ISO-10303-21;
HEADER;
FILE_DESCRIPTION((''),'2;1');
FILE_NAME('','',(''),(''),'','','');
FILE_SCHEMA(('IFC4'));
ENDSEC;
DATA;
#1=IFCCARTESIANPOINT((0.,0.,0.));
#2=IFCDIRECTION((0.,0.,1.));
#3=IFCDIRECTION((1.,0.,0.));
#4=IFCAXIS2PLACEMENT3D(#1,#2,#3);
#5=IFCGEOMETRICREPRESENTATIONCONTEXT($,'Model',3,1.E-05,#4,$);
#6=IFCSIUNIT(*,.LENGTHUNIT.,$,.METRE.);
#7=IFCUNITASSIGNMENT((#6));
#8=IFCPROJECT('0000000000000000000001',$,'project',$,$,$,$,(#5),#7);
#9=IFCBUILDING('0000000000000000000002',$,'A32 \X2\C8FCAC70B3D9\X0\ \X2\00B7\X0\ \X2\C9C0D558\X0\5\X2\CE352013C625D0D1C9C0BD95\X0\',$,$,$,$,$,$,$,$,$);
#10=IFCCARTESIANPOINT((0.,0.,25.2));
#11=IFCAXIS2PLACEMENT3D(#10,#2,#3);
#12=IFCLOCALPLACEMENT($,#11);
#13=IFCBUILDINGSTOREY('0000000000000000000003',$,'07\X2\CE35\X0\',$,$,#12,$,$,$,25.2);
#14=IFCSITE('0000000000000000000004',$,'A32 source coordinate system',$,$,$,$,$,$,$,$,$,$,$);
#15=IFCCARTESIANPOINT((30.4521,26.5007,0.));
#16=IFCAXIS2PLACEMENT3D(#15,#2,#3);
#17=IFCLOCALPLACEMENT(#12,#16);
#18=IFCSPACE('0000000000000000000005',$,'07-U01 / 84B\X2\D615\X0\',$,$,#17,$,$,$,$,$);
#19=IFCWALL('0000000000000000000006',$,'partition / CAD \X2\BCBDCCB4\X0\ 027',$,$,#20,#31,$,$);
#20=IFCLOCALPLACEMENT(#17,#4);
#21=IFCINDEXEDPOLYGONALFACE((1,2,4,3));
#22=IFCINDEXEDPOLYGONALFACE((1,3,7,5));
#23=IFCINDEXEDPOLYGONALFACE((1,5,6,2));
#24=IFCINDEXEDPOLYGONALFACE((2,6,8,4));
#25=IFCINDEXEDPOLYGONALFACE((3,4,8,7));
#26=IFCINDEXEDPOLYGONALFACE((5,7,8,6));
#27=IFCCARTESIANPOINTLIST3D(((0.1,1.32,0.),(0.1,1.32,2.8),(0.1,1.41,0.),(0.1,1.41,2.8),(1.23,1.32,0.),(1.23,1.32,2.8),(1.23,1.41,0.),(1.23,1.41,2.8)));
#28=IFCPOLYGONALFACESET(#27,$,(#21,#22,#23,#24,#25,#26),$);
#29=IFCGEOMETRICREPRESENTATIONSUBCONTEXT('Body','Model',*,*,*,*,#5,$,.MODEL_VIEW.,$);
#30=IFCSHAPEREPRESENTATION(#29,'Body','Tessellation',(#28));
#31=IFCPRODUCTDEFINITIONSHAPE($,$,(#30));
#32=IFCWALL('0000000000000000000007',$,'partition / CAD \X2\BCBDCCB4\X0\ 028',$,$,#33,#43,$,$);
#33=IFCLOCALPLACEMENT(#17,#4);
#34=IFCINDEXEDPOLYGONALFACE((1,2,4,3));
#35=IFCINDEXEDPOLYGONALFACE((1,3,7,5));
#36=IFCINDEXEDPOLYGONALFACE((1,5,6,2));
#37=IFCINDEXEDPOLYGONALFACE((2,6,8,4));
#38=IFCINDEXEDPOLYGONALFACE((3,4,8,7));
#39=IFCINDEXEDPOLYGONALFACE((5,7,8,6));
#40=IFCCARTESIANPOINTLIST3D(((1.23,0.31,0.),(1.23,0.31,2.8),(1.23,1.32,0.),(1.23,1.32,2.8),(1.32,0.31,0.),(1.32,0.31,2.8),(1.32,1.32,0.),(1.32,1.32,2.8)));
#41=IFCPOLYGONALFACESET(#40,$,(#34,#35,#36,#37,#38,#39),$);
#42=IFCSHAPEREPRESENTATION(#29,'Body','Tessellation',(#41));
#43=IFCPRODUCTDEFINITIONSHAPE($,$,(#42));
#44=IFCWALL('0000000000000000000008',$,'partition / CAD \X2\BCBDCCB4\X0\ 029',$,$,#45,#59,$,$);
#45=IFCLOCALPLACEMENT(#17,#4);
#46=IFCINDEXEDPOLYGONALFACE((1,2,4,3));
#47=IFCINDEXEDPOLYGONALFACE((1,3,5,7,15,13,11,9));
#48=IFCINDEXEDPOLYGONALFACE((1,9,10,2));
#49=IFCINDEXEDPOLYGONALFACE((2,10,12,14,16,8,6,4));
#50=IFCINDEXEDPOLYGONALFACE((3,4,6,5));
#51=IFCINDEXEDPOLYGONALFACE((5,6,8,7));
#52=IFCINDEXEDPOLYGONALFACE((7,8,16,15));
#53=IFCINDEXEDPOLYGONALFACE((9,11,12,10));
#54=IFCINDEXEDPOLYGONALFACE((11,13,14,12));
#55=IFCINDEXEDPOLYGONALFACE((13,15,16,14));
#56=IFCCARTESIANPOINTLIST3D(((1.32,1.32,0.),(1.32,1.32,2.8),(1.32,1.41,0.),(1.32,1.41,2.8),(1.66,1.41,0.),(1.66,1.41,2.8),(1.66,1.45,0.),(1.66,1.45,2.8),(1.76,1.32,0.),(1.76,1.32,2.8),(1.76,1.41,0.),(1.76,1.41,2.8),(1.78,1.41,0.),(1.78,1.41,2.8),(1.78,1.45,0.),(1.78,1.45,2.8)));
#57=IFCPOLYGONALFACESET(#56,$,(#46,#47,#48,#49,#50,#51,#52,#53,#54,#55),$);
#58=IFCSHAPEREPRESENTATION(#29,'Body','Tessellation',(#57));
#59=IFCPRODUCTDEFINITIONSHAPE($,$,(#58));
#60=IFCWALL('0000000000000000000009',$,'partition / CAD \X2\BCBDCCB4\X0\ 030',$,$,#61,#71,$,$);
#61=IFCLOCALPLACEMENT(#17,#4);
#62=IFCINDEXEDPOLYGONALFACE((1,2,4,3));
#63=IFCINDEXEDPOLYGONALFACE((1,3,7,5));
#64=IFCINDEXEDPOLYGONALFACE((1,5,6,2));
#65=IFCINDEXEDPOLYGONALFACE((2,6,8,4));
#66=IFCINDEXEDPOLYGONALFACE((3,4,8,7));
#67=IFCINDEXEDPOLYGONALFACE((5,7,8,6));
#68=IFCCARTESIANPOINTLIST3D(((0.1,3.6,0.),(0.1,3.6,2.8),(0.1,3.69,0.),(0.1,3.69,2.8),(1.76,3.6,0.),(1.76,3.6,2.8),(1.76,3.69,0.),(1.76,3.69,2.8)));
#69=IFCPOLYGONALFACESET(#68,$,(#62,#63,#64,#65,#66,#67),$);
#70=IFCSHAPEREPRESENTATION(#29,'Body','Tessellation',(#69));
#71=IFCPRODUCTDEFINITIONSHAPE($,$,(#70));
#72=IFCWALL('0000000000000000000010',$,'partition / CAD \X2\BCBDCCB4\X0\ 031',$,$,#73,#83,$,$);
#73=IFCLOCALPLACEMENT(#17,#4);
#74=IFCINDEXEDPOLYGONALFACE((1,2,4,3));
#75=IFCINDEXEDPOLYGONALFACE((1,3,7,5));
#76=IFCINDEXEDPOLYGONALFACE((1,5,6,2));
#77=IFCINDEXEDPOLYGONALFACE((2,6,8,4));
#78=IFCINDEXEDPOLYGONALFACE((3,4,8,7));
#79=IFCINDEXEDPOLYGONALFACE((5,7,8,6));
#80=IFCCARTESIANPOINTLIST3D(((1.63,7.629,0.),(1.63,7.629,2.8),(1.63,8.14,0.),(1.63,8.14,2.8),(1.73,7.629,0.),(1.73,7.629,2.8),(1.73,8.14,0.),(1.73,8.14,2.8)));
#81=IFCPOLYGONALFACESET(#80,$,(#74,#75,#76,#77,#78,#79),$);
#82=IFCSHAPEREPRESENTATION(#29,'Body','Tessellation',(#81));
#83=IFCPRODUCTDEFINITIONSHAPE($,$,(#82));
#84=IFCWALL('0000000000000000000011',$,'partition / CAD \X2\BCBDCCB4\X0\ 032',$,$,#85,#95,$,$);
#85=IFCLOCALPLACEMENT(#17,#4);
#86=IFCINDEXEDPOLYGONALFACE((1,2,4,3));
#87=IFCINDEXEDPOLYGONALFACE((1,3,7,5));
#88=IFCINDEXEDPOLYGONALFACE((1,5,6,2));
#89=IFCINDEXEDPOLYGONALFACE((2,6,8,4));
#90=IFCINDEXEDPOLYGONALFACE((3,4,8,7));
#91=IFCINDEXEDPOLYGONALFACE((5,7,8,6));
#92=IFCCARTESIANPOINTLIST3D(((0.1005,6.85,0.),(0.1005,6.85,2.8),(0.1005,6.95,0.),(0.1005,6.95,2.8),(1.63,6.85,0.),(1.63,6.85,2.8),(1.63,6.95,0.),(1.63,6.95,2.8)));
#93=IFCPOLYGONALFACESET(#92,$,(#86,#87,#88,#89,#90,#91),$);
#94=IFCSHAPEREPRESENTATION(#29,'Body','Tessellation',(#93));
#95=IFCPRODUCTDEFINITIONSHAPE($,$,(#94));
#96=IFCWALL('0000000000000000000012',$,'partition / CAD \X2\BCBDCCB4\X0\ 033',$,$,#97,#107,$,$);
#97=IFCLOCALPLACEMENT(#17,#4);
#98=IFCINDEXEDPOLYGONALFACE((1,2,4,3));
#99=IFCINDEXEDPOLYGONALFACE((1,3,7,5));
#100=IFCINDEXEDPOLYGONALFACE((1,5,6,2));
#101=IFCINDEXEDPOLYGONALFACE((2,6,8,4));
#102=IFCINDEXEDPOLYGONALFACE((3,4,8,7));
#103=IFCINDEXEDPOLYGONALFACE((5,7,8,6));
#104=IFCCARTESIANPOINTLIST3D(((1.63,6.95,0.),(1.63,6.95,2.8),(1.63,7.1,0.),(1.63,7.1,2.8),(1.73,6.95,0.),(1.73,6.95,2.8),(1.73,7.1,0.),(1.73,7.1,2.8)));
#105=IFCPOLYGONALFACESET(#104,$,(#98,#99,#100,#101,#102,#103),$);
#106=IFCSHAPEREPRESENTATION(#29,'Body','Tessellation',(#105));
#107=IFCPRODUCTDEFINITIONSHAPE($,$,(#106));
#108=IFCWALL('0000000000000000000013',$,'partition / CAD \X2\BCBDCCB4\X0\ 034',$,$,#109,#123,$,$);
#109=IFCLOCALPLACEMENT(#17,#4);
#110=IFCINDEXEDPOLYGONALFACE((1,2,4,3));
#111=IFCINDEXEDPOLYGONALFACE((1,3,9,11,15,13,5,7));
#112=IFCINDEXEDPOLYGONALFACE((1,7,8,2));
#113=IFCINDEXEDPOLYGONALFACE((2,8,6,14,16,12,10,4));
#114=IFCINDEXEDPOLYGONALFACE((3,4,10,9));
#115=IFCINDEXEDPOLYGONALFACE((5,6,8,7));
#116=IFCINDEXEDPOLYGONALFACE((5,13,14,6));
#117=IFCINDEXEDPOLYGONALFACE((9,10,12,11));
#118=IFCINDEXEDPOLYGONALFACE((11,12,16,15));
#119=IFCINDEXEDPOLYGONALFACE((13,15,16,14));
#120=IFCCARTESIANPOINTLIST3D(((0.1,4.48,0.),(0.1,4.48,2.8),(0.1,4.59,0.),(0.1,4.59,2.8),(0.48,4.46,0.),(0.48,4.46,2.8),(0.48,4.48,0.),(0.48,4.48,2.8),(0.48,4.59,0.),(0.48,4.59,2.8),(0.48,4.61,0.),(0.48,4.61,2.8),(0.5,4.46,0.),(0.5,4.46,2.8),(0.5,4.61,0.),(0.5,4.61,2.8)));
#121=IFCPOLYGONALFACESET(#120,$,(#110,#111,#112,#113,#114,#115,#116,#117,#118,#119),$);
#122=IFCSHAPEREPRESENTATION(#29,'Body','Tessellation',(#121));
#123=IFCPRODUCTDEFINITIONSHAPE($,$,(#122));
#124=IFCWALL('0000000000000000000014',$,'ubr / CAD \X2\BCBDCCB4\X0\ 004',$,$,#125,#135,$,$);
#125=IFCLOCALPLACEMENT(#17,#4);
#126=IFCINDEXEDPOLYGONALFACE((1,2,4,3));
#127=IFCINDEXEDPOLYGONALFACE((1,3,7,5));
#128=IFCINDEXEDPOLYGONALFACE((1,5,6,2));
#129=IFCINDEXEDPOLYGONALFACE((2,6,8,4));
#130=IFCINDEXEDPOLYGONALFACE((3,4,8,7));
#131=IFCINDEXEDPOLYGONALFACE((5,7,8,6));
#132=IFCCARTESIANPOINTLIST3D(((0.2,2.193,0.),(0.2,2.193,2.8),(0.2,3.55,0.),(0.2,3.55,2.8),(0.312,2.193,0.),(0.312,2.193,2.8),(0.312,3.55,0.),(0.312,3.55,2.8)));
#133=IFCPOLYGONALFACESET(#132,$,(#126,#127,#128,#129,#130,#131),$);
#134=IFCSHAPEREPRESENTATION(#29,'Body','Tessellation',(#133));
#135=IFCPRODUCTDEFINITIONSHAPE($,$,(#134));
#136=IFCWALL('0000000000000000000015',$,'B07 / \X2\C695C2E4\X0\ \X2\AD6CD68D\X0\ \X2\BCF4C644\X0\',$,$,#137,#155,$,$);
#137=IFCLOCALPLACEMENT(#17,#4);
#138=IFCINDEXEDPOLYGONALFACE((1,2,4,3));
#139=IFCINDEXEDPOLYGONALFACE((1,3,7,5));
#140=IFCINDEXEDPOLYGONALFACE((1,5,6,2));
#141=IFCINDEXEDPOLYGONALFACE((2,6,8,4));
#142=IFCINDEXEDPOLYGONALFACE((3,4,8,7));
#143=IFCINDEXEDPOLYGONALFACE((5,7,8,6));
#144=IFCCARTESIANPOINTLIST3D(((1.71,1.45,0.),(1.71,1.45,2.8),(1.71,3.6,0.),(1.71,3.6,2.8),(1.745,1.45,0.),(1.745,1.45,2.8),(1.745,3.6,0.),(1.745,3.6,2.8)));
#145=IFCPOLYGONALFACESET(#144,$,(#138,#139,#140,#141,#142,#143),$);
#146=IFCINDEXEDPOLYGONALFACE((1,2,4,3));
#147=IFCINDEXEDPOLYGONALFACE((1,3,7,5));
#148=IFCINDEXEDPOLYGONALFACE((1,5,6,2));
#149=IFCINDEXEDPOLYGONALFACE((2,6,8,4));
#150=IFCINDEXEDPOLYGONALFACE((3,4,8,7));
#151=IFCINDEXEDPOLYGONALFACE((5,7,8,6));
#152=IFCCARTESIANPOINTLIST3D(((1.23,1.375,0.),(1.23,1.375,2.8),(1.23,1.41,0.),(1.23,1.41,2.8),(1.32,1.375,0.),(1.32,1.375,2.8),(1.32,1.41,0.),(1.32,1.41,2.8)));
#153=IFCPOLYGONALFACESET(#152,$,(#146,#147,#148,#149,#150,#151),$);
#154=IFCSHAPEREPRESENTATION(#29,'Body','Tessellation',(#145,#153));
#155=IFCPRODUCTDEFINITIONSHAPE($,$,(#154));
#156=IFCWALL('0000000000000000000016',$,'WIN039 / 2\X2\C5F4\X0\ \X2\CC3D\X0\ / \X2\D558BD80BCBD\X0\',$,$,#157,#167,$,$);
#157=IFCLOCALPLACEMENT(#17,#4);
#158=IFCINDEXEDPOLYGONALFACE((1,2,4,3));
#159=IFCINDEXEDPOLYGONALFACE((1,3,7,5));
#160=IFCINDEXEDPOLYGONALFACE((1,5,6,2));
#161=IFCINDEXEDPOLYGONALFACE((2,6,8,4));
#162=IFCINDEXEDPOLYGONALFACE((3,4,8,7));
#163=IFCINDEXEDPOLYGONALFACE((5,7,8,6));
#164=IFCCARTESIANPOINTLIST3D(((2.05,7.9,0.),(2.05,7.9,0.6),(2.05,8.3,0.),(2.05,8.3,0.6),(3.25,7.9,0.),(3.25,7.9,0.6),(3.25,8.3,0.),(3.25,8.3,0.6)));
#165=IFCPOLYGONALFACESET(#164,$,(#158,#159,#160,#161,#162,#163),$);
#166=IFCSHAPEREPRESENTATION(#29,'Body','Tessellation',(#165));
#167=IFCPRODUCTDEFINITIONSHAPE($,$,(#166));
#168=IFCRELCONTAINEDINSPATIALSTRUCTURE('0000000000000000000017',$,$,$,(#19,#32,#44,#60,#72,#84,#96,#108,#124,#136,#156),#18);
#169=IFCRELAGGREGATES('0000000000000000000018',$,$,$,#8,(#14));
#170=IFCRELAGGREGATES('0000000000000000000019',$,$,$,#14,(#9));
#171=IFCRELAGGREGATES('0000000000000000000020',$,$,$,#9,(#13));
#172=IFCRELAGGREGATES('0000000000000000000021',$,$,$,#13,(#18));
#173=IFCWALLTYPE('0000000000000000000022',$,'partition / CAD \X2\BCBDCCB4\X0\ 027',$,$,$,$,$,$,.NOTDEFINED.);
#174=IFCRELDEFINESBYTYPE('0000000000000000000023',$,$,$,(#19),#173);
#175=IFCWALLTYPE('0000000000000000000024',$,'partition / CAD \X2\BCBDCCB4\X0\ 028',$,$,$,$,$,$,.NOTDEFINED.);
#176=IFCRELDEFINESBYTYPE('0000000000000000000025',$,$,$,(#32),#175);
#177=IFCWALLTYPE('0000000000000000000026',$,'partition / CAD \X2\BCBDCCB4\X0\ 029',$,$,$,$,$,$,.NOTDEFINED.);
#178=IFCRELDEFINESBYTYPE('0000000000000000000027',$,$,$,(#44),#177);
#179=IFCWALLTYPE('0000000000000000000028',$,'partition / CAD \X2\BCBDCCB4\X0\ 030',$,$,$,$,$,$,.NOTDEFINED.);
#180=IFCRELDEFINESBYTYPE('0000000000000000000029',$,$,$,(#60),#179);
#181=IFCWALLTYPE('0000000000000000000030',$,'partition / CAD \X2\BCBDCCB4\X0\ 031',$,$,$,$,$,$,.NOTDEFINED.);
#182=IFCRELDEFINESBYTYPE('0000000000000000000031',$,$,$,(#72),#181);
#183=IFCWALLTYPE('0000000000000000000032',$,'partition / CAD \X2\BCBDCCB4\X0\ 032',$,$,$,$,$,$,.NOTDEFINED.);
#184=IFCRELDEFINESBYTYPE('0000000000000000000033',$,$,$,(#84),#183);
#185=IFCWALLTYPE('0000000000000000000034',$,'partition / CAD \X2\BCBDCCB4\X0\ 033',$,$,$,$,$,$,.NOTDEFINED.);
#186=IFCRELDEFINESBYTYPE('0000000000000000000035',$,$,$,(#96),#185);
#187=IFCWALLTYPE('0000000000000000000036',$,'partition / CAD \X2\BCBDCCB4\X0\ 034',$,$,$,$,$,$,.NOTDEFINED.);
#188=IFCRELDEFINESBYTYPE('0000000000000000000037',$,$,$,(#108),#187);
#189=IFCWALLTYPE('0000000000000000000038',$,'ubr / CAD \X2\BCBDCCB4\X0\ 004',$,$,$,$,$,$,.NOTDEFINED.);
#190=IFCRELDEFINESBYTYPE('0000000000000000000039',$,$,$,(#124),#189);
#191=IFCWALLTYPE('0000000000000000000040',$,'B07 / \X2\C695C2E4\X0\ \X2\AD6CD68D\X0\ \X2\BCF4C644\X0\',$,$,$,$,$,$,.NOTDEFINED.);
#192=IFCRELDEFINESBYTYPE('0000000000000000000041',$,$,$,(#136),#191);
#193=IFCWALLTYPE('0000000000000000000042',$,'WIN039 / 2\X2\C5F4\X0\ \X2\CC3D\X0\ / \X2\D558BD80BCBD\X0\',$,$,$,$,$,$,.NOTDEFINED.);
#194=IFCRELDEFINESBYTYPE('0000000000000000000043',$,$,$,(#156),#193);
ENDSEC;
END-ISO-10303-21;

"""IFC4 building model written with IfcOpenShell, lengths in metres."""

from ifc_helpers import new_model, si_unit, frame, origin, origin_with_axes, place, context, subcontext, project, spatial, polyline, outline, extrude, source, transform, mapped, type_object, type_shapes, element, save


model = new_model("IFC4")

# Units and contexts
model_context = context("Model", 3, precision=1e-05, world=origin_with_axes())
body_context = subcontext(model_context, "Body", "Model", "MODEL_VIEW")
ifc_project = project(units=[si_unit("LENGTHUNIT", "METRE")], contexts=[model_context])

# Site, building, storey, space
site = spatial("IfcSite", under=ifc_project, Name="A32 source coordinate system")
building = spatial("IfcBuilding", under=site, Name="A32 주거동 · 지하5층–옥탑지붕")
storey_placement = place(None, frame((0.0, 0.0, 25.2), z_axis=(0.0, 0.0, 1.0), x_axis=(1.0, 0.0, 0.0)))
storey = spatial("IfcBuildingStorey", under=building, at=storey_placement, Name="07층", Elevation=25.2)
space_placement = place(storey_placement, frame((30.4521, 26.5007, 0.0), z_axis=(0.0, 0.0, 1.0), x_axis=(1.0, 0.0, 0.0)))
space = spatial("IfcSpace", under=storey, at=space_placement, Name="07-U01 / 84B형")

# Walls
wall_type_1 = type_object("IfcWallType", Name="partition / CAD 벽체 027", PredefinedType="NOTDEFINED")
shared_shape_1 = source(origin(), body_context, "Body", "SweptSolid", [
    extrude(outline(polyline([(0.1, 1.32), (0.1, 1.41), (1.23, 1.41), (1.23, 1.32), (0.1, 1.32)])), origin(), (0.0, 0.0, 1.0), 2.8),
])
type_shapes(wall_type_1, [shared_shape_1])
wall_1_placement = place(space_placement, origin_with_axes())
element("IfcWall", 1, at=wall_1_placement, inside=space, type_object=wall_type_1, Name="partition / CAD 벽체 027", context=body_context, shape_type="MappedRepresentation", body=[
    mapped(shared_shape_1, transform((0.0, 0.0, 0.0), scale=1.0)),
])
wall_type_2 = type_object("IfcWallType", Name="partition / CAD 벽체 028", PredefinedType="NOTDEFINED")
shared_shape_2 = source(origin(), body_context, "Body", "SweptSolid", [
    extrude(outline(polyline([(1.32, 0.31), (1.23, 0.31), (1.23, 1.32), (1.32, 1.32), (1.32, 0.31)])), origin(), (0.0, 0.0, 1.0), 2.8),
])
type_shapes(wall_type_2, [shared_shape_2])
wall_2_placement = place(space_placement, origin_with_axes())
element("IfcWall", 2, at=wall_2_placement, inside=space, type_object=wall_type_2, Name="partition / CAD 벽체 028", context=body_context, shape_type="MappedRepresentation", body=[
    mapped(shared_shape_2, transform((0.0, 0.0, 0.0), scale=1.0)),
])
wall_type_3 = type_object("IfcWallType", Name="partition / CAD 벽체 029", PredefinedType="NOTDEFINED")
shared_shape_3 = source(origin(), body_context, "Body", "SweptSolid", [
    extrude(outline(polyline([(1.66, 1.41), (1.66, 1.45), (1.78, 1.45), (1.78, 1.41), (1.76, 1.41), (1.76, 1.32), (1.32, 1.32), (1.32, 1.41), (1.66, 1.41)])), origin(), (0.0, 0.0, 1.0), 2.8),
])
type_shapes(wall_type_3, [shared_shape_3])
wall_3_placement = place(space_placement, origin_with_axes())
element("IfcWall", 3, at=wall_3_placement, inside=space, type_object=wall_type_3, Name="partition / CAD 벽체 029", context=body_context, shape_type="MappedRepresentation", body=[
    mapped(shared_shape_3, transform((0.0, 0.0, 0.0), scale=1.0)),
])
wall_type_4 = type_object("IfcWallType", Name="partition / CAD 벽체 030", PredefinedType="NOTDEFINED")
shared_shape_4 = source(origin(), body_context, "Body", "SweptSolid", [
    extrude(outline(polyline([(1.76, 3.69), (1.76, 3.6), (0.1, 3.6), (0.1, 3.69), (1.76, 3.69)])), origin(), (0.0, 0.0, 1.0), 2.8),
])
type_shapes(wall_type_4, [shared_shape_4])
wall_4_placement = place(space_placement, origin_with_axes())
element("IfcWall", 4, at=wall_4_placement, inside=space, type_object=wall_type_4, Name="partition / CAD 벽체 030", context=body_context, shape_type="MappedRepresentation", body=[
    mapped(shared_shape_4, transform((0.0, 0.0, 0.0), scale=1.0)),
])
wall_type_5 = type_object("IfcWallType", Name="partition / CAD 벽체 031", PredefinedType="NOTDEFINED")
shared_shape_5 = source(origin(), body_context, "Body", "SweptSolid", [
    extrude(outline(polyline([(1.63, 8.14), (1.73, 8.14), (1.73, 7.629), (1.63, 7.629), (1.63, 8.14)])), origin(), (0.0, 0.0, 1.0), 2.8),
])
type_shapes(wall_type_5, [shared_shape_5])
wall_5_placement = place(space_placement, origin_with_axes())
element("IfcWall", 5, at=wall_5_placement, inside=space, type_object=wall_type_5, Name="partition / CAD 벽체 031", context=body_context, shape_type="MappedRepresentation", body=[
    mapped(shared_shape_5, transform((0.0, 0.0, 0.0), scale=1.0)),
])
wall_type_6 = type_object("IfcWallType", Name="partition / CAD 벽체 032", PredefinedType="NOTDEFINED")
shared_shape_6 = source(origin(), body_context, "Body", "SweptSolid", [
    extrude(outline(polyline([(0.1005, 6.95), (1.63, 6.95), (1.63, 6.85), (0.1005, 6.85), (0.1005, 6.95)])), origin(), (0.0, 0.0, 1.0), 2.8),
])
type_shapes(wall_type_6, [shared_shape_6])
wall_6_placement = place(space_placement, origin_with_axes())
element("IfcWall", 6, at=wall_6_placement, inside=space, type_object=wall_type_6, Name="partition / CAD 벽체 032", context=body_context, shape_type="MappedRepresentation", body=[
    mapped(shared_shape_6, transform((0.0, 0.0, 0.0), scale=1.0)),
])
wall_type_7 = type_object("IfcWallType", Name="partition / CAD 벽체 033", PredefinedType="NOTDEFINED")
shared_shape_7 = source(origin(), body_context, "Body", "SweptSolid", [
    extrude(outline(polyline([(1.63, 7.1), (1.73, 7.1), (1.73, 6.95), (1.63, 6.95), (1.63, 7.1)])), origin(), (0.0, 0.0, 1.0), 2.8),
])
type_shapes(wall_type_7, [shared_shape_7])
wall_7_placement = place(space_placement, origin_with_axes())
element("IfcWall", 7, at=wall_7_placement, inside=space, type_object=wall_type_7, Name="partition / CAD 벽체 033", context=body_context, shape_type="MappedRepresentation", body=[
    mapped(shared_shape_7, transform((0.0, 0.0, 0.0), scale=1.0)),
])
wall_type_8 = type_object("IfcWallType", Name="partition / CAD 벽체 034", PredefinedType="NOTDEFINED")
shared_shape_8 = source(origin(), body_context, "Body", "SweptSolid", [
    extrude(outline(polyline([(0.48, 4.61), (0.5, 4.61), (0.5, 4.46), (0.48, 4.46), (0.48, 4.48), (0.1, 4.48), (0.1, 4.59), (0.48, 4.59), (0.48, 4.61)])), origin(), (0.0, 0.0, 1.0), 2.8),
])
type_shapes(wall_type_8, [shared_shape_8])
wall_8_placement = place(space_placement, origin_with_axes())
element("IfcWall", 8, at=wall_8_placement, inside=space, type_object=wall_type_8, Name="partition / CAD 벽체 034", context=body_context, shape_type="MappedRepresentation", body=[
    mapped(shared_shape_8, transform((0.0, 0.0, 0.0), scale=1.0)),
])
wall_type_9 = type_object("IfcWallType", Name="ubr / CAD 벽체 004", PredefinedType="NOTDEFINED")
shared_shape_9 = source(origin(), body_context, "Body", "SweptSolid", [
    extrude(outline(polyline([(0.312, 2.193), (0.2, 2.193), (0.2, 3.55), (0.312, 3.55), (0.312, 2.193)])), origin(), (0.0, 0.0, 1.0), 2.8),
])
type_shapes(wall_type_9, [shared_shape_9])
wall_9_placement = place(space_placement, origin_with_axes())
element("IfcWall", 9, at=wall_9_placement, inside=space, type_object=wall_type_9, Name="ubr / CAD 벽체 004", context=body_context, shape_type="MappedRepresentation", body=[
    mapped(shared_shape_9, transform((0.0, 0.0, 0.0), scale=1.0)),
])
wall_type_10 = type_object("IfcWallType", Name="B07 / 욕실 구획 보완", PredefinedType="NOTDEFINED")
shared_shape_10 = source(origin(), body_context, "Body", "SweptSolid", [
    extrude(outline(polyline([(1.71, 1.45), (1.71, 3.6), (1.745, 3.6), (1.745, 1.45), (1.71, 1.45)])), origin(), (0.0, 0.0, 1.0), 2.8),
    extrude(outline(polyline([(1.32, 1.41), (1.32, 1.375), (1.23, 1.375), (1.23, 1.41), (1.32, 1.41)])), origin(), (0.0, 0.0, 1.0), 2.8),
])
type_shapes(wall_type_10, [shared_shape_10])
wall_10_placement = place(space_placement, origin_with_axes())
element("IfcWall", 10, at=wall_10_placement, inside=space, type_object=wall_type_10, Name="B07 / 욕실 구획 보완", context=body_context, shape_type="MappedRepresentation", body=[
    mapped(shared_shape_10, transform((0.0, 0.0, 0.0), scale=1.0)),
])
wall_type_11 = type_object("IfcWallType", Name="WIN039 / 2열 창 / 하부벽", PredefinedType="NOTDEFINED")
shared_shape_11 = source(origin(), body_context, "Body", "SweptSolid", [
    extrude(outline(polyline([(2.05, 8.3), (3.25, 8.3), (3.25, 7.9), (2.05, 7.9), (2.05, 8.3)])), origin(), (0.0, 0.0, 1.0), 0.6),
])
type_shapes(wall_type_11, [shared_shape_11])
wall_11_placement = place(space_placement, origin_with_axes())
element("IfcWall", 11, at=wall_11_placement, inside=space, type_object=wall_type_11, Name="WIN039 / 2열 창 / 하부벽", context=body_context, shape_type="MappedRepresentation", body=[
    mapped(shared_shape_11, transform((0.0, 0.0, 0.0), scale=1.0)),
])

save(model, "model.ifc")
